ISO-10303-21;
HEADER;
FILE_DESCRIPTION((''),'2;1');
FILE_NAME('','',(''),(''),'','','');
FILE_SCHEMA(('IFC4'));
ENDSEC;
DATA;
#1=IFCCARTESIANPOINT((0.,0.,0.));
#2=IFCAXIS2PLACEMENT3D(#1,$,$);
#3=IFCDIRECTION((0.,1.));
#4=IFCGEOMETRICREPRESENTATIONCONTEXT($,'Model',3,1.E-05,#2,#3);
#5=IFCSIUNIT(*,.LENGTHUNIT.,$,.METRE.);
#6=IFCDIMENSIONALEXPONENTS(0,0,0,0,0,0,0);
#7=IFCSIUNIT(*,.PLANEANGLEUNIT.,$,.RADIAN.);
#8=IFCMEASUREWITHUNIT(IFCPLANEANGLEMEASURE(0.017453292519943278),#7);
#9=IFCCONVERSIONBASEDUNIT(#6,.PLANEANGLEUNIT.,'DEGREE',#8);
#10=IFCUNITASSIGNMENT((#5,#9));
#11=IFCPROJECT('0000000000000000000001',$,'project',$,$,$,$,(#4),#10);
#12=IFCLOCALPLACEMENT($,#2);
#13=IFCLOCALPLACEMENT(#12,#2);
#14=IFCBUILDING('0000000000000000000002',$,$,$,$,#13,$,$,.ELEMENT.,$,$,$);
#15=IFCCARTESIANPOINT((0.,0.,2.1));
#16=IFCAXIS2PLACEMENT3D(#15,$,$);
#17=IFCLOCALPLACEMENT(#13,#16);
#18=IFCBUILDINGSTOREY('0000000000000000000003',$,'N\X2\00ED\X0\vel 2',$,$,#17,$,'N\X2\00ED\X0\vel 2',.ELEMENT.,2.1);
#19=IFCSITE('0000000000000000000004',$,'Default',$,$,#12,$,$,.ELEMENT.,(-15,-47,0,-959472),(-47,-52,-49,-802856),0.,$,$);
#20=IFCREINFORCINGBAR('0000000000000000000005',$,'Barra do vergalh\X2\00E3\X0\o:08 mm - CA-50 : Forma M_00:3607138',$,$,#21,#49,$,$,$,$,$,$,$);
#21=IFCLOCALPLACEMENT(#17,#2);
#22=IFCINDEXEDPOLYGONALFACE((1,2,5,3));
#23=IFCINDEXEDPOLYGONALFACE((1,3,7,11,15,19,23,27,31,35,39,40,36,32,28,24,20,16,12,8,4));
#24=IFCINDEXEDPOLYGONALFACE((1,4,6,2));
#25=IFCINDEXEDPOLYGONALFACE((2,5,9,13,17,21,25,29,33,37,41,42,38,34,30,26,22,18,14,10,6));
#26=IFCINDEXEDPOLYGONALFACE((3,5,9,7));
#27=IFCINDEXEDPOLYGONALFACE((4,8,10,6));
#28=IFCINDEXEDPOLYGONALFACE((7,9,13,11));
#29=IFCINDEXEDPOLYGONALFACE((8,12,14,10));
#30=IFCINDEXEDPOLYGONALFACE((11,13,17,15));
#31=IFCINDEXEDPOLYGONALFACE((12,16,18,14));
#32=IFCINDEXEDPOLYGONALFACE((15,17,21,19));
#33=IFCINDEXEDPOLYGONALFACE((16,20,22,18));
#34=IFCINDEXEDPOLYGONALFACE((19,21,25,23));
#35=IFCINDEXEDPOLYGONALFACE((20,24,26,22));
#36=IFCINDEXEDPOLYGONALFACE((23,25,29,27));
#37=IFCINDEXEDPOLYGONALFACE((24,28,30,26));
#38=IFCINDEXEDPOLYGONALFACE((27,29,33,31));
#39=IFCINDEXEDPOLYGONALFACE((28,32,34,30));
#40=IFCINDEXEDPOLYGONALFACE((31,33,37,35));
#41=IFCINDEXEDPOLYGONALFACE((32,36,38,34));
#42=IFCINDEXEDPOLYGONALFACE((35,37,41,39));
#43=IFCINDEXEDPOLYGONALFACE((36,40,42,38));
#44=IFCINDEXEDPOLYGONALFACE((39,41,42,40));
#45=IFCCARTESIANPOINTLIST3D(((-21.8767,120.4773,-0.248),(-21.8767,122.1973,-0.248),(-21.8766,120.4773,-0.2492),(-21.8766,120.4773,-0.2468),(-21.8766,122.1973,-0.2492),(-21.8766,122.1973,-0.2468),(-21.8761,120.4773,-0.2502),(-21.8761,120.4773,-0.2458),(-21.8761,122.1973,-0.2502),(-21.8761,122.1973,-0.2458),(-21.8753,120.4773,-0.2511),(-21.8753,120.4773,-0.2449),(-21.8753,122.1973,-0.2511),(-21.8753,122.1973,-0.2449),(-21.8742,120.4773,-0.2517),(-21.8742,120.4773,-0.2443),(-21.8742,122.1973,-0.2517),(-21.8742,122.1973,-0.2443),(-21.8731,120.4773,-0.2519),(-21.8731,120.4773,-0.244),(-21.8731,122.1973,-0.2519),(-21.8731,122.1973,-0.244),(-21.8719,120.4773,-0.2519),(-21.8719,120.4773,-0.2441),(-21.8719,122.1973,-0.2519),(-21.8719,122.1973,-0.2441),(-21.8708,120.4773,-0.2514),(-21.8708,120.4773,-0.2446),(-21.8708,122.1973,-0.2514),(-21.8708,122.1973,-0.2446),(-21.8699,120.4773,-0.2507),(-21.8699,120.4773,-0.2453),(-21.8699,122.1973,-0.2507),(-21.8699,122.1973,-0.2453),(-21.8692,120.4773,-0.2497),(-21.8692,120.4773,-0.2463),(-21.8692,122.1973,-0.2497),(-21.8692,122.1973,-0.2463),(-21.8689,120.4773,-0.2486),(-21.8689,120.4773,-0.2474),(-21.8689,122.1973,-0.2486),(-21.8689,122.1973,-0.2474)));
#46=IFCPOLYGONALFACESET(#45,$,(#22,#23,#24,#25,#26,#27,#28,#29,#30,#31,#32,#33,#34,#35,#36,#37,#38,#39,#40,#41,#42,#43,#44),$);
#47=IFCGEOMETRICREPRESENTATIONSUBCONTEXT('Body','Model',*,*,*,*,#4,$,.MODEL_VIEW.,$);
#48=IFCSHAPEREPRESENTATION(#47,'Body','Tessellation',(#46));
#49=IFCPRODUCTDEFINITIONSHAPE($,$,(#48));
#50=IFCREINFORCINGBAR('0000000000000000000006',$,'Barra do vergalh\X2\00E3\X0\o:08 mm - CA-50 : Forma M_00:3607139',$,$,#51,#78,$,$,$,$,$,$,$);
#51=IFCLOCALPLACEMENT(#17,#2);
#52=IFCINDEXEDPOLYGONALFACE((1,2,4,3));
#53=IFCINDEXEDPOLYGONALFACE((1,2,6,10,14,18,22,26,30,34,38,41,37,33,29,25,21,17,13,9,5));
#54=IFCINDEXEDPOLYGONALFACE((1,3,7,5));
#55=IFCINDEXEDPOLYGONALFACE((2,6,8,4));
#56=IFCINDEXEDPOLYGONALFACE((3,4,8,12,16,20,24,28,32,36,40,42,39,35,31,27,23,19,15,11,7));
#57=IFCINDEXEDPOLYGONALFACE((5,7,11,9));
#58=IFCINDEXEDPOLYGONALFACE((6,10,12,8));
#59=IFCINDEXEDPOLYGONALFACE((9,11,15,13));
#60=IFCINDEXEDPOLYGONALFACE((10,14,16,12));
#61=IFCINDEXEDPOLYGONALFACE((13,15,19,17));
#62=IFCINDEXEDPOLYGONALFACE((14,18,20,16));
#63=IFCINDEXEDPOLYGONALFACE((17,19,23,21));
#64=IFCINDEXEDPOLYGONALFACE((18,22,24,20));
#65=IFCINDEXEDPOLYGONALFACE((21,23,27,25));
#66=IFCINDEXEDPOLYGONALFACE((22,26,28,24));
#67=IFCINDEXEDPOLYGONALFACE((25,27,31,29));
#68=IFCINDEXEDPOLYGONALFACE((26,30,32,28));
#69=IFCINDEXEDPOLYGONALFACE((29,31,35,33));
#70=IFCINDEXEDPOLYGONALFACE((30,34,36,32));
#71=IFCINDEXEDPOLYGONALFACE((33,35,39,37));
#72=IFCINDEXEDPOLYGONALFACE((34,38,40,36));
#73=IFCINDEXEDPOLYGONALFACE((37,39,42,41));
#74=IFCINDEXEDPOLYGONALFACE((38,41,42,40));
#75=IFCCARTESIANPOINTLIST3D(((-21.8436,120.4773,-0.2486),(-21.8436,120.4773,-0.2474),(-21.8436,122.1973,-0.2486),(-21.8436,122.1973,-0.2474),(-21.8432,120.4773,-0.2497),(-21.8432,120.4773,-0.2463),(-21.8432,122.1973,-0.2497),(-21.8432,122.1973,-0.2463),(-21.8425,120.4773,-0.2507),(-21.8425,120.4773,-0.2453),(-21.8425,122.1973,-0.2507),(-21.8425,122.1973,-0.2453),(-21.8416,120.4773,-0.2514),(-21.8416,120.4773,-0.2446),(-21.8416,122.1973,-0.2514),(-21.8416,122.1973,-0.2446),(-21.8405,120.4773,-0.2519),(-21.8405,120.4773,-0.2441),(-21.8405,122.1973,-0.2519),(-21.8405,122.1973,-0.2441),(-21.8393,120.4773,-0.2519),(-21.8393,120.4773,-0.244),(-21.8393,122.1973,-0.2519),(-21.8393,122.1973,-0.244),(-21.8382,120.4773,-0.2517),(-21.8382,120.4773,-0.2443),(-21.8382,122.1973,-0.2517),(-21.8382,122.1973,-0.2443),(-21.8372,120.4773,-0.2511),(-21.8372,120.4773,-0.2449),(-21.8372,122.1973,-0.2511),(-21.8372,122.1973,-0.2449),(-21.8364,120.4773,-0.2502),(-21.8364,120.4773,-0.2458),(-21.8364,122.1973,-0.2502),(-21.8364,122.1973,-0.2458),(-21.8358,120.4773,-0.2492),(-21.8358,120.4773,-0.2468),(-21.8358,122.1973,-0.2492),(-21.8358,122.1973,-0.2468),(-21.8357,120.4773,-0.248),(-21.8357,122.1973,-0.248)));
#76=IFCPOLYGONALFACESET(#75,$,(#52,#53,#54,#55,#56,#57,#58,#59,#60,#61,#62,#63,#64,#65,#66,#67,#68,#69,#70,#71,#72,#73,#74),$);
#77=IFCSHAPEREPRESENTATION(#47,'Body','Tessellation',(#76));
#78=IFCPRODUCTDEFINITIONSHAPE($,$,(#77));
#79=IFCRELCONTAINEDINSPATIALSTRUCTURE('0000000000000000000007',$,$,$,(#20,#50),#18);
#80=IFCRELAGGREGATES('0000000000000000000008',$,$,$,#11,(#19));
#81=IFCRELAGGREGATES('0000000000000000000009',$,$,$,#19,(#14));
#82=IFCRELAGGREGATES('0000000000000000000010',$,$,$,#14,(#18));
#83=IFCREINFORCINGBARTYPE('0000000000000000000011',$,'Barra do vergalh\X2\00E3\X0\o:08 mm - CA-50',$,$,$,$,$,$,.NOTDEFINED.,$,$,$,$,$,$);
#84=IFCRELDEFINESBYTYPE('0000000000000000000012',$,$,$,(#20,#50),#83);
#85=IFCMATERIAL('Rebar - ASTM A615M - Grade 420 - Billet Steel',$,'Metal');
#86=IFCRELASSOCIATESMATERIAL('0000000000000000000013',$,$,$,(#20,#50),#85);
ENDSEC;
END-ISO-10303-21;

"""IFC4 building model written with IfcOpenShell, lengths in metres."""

from ifc_helpers import new_model, entity, si_unit, converted_unit, direction, frame, origin, place, context, subcontext, project, spatial, material, type_object, element, save


model = new_model("IFC4")

# Units and contexts
model_context = context("Model", 3, precision=1e-05, world=origin(), true_north=direction((0.0, 1.0)))
body_context = subcontext(model_context, "Body", "Model", "MODEL_VIEW")
ifc_project = project(units=[si_unit("LENGTHUNIT", "METRE"), converted_unit("PLANEANGLEUNIT", "DEGREE", entity("IfcPlaneAngleMeasure", 0.017453292519943278), si_unit("PLANEANGLEUNIT", "RADIAN"), dimensions=[0, 0, 0, 0, 0, 0, 0])], contexts=[model_context])

# Site, building, storey
site_placement = place(None, origin())
site = spatial("IfcSite", under=ifc_project, at=site_placement, Name="Default", CompositionType="ELEMENT", RefLatitude=(-15, -47, 0, -959472), RefLongitude=(-47, -52, -49, -802856), RefElevation=0.0)
building_placement = place(site_placement, origin())
building = spatial("IfcBuilding", under=site, at=building_placement, CompositionType="ELEMENT")
storey_placement = place(building_placement, frame((0.0, 0.0, 2.1)))
storey = spatial("IfcBuildingStorey", under=building, at=storey_placement, Name="Nível 2", LongName="Nível 2", CompositionType="ELEMENT", Elevation=2.1)

# Reinforcing bars
ifc_material = material(Name="Rebar - ASTM A615M - Grade 420 - Billet Steel", Category="Metal")
reinforcing_bar_type_1 = type_object("IfcReinforcingBarType", Name="Barra do vergalhão:08 mm - CA-50", PredefinedType="NOTDEFINED")
reinforcing_bar_1_placement = place(storey_placement, origin())
element("IfcReinforcingBar", 1, at=reinforcing_bar_1_placement, inside=storey, type_object=reinforcing_bar_type_1, material=ifc_material, Name="Barra do vergalhão:08 mm - CA-50 : Forma M_00:3607138", context=body_context, shape_type="AdvancedSweptSolid", body=[
    entity("IfcSweptDiskSolid", entity("IfcIndexedPolyCurve", entity("IfcCartesianPointList3D", [[21.8728, -120.4773, 0.248], [21.8728, -122.1973, 0.248]]), None, False), 0.004, None, 0.0, 1.0),
])
reinforcing_bar_2_placement = place(storey_placement, origin())
element("IfcReinforcingBar", 2, at=reinforcing_bar_2_placement, inside=storey, type_object=reinforcing_bar_type_1, material=ifc_material, Name="Barra do vergalhão:08 mm - CA-50 : Forma M_00:3607139", context=body_context, shape_type="AdvancedSweptSolid", body=[
    entity("IfcSweptDiskSolid", entity("IfcIndexedPolyCurve", entity("IfcCartesianPointList3D", [[21.8396, -122.1973, 0.248], [21.8396, -120.4773, 0.248]]), None, False), 0.004, None, 0.0, 1.0),
])

save(model, "model.ifc")
